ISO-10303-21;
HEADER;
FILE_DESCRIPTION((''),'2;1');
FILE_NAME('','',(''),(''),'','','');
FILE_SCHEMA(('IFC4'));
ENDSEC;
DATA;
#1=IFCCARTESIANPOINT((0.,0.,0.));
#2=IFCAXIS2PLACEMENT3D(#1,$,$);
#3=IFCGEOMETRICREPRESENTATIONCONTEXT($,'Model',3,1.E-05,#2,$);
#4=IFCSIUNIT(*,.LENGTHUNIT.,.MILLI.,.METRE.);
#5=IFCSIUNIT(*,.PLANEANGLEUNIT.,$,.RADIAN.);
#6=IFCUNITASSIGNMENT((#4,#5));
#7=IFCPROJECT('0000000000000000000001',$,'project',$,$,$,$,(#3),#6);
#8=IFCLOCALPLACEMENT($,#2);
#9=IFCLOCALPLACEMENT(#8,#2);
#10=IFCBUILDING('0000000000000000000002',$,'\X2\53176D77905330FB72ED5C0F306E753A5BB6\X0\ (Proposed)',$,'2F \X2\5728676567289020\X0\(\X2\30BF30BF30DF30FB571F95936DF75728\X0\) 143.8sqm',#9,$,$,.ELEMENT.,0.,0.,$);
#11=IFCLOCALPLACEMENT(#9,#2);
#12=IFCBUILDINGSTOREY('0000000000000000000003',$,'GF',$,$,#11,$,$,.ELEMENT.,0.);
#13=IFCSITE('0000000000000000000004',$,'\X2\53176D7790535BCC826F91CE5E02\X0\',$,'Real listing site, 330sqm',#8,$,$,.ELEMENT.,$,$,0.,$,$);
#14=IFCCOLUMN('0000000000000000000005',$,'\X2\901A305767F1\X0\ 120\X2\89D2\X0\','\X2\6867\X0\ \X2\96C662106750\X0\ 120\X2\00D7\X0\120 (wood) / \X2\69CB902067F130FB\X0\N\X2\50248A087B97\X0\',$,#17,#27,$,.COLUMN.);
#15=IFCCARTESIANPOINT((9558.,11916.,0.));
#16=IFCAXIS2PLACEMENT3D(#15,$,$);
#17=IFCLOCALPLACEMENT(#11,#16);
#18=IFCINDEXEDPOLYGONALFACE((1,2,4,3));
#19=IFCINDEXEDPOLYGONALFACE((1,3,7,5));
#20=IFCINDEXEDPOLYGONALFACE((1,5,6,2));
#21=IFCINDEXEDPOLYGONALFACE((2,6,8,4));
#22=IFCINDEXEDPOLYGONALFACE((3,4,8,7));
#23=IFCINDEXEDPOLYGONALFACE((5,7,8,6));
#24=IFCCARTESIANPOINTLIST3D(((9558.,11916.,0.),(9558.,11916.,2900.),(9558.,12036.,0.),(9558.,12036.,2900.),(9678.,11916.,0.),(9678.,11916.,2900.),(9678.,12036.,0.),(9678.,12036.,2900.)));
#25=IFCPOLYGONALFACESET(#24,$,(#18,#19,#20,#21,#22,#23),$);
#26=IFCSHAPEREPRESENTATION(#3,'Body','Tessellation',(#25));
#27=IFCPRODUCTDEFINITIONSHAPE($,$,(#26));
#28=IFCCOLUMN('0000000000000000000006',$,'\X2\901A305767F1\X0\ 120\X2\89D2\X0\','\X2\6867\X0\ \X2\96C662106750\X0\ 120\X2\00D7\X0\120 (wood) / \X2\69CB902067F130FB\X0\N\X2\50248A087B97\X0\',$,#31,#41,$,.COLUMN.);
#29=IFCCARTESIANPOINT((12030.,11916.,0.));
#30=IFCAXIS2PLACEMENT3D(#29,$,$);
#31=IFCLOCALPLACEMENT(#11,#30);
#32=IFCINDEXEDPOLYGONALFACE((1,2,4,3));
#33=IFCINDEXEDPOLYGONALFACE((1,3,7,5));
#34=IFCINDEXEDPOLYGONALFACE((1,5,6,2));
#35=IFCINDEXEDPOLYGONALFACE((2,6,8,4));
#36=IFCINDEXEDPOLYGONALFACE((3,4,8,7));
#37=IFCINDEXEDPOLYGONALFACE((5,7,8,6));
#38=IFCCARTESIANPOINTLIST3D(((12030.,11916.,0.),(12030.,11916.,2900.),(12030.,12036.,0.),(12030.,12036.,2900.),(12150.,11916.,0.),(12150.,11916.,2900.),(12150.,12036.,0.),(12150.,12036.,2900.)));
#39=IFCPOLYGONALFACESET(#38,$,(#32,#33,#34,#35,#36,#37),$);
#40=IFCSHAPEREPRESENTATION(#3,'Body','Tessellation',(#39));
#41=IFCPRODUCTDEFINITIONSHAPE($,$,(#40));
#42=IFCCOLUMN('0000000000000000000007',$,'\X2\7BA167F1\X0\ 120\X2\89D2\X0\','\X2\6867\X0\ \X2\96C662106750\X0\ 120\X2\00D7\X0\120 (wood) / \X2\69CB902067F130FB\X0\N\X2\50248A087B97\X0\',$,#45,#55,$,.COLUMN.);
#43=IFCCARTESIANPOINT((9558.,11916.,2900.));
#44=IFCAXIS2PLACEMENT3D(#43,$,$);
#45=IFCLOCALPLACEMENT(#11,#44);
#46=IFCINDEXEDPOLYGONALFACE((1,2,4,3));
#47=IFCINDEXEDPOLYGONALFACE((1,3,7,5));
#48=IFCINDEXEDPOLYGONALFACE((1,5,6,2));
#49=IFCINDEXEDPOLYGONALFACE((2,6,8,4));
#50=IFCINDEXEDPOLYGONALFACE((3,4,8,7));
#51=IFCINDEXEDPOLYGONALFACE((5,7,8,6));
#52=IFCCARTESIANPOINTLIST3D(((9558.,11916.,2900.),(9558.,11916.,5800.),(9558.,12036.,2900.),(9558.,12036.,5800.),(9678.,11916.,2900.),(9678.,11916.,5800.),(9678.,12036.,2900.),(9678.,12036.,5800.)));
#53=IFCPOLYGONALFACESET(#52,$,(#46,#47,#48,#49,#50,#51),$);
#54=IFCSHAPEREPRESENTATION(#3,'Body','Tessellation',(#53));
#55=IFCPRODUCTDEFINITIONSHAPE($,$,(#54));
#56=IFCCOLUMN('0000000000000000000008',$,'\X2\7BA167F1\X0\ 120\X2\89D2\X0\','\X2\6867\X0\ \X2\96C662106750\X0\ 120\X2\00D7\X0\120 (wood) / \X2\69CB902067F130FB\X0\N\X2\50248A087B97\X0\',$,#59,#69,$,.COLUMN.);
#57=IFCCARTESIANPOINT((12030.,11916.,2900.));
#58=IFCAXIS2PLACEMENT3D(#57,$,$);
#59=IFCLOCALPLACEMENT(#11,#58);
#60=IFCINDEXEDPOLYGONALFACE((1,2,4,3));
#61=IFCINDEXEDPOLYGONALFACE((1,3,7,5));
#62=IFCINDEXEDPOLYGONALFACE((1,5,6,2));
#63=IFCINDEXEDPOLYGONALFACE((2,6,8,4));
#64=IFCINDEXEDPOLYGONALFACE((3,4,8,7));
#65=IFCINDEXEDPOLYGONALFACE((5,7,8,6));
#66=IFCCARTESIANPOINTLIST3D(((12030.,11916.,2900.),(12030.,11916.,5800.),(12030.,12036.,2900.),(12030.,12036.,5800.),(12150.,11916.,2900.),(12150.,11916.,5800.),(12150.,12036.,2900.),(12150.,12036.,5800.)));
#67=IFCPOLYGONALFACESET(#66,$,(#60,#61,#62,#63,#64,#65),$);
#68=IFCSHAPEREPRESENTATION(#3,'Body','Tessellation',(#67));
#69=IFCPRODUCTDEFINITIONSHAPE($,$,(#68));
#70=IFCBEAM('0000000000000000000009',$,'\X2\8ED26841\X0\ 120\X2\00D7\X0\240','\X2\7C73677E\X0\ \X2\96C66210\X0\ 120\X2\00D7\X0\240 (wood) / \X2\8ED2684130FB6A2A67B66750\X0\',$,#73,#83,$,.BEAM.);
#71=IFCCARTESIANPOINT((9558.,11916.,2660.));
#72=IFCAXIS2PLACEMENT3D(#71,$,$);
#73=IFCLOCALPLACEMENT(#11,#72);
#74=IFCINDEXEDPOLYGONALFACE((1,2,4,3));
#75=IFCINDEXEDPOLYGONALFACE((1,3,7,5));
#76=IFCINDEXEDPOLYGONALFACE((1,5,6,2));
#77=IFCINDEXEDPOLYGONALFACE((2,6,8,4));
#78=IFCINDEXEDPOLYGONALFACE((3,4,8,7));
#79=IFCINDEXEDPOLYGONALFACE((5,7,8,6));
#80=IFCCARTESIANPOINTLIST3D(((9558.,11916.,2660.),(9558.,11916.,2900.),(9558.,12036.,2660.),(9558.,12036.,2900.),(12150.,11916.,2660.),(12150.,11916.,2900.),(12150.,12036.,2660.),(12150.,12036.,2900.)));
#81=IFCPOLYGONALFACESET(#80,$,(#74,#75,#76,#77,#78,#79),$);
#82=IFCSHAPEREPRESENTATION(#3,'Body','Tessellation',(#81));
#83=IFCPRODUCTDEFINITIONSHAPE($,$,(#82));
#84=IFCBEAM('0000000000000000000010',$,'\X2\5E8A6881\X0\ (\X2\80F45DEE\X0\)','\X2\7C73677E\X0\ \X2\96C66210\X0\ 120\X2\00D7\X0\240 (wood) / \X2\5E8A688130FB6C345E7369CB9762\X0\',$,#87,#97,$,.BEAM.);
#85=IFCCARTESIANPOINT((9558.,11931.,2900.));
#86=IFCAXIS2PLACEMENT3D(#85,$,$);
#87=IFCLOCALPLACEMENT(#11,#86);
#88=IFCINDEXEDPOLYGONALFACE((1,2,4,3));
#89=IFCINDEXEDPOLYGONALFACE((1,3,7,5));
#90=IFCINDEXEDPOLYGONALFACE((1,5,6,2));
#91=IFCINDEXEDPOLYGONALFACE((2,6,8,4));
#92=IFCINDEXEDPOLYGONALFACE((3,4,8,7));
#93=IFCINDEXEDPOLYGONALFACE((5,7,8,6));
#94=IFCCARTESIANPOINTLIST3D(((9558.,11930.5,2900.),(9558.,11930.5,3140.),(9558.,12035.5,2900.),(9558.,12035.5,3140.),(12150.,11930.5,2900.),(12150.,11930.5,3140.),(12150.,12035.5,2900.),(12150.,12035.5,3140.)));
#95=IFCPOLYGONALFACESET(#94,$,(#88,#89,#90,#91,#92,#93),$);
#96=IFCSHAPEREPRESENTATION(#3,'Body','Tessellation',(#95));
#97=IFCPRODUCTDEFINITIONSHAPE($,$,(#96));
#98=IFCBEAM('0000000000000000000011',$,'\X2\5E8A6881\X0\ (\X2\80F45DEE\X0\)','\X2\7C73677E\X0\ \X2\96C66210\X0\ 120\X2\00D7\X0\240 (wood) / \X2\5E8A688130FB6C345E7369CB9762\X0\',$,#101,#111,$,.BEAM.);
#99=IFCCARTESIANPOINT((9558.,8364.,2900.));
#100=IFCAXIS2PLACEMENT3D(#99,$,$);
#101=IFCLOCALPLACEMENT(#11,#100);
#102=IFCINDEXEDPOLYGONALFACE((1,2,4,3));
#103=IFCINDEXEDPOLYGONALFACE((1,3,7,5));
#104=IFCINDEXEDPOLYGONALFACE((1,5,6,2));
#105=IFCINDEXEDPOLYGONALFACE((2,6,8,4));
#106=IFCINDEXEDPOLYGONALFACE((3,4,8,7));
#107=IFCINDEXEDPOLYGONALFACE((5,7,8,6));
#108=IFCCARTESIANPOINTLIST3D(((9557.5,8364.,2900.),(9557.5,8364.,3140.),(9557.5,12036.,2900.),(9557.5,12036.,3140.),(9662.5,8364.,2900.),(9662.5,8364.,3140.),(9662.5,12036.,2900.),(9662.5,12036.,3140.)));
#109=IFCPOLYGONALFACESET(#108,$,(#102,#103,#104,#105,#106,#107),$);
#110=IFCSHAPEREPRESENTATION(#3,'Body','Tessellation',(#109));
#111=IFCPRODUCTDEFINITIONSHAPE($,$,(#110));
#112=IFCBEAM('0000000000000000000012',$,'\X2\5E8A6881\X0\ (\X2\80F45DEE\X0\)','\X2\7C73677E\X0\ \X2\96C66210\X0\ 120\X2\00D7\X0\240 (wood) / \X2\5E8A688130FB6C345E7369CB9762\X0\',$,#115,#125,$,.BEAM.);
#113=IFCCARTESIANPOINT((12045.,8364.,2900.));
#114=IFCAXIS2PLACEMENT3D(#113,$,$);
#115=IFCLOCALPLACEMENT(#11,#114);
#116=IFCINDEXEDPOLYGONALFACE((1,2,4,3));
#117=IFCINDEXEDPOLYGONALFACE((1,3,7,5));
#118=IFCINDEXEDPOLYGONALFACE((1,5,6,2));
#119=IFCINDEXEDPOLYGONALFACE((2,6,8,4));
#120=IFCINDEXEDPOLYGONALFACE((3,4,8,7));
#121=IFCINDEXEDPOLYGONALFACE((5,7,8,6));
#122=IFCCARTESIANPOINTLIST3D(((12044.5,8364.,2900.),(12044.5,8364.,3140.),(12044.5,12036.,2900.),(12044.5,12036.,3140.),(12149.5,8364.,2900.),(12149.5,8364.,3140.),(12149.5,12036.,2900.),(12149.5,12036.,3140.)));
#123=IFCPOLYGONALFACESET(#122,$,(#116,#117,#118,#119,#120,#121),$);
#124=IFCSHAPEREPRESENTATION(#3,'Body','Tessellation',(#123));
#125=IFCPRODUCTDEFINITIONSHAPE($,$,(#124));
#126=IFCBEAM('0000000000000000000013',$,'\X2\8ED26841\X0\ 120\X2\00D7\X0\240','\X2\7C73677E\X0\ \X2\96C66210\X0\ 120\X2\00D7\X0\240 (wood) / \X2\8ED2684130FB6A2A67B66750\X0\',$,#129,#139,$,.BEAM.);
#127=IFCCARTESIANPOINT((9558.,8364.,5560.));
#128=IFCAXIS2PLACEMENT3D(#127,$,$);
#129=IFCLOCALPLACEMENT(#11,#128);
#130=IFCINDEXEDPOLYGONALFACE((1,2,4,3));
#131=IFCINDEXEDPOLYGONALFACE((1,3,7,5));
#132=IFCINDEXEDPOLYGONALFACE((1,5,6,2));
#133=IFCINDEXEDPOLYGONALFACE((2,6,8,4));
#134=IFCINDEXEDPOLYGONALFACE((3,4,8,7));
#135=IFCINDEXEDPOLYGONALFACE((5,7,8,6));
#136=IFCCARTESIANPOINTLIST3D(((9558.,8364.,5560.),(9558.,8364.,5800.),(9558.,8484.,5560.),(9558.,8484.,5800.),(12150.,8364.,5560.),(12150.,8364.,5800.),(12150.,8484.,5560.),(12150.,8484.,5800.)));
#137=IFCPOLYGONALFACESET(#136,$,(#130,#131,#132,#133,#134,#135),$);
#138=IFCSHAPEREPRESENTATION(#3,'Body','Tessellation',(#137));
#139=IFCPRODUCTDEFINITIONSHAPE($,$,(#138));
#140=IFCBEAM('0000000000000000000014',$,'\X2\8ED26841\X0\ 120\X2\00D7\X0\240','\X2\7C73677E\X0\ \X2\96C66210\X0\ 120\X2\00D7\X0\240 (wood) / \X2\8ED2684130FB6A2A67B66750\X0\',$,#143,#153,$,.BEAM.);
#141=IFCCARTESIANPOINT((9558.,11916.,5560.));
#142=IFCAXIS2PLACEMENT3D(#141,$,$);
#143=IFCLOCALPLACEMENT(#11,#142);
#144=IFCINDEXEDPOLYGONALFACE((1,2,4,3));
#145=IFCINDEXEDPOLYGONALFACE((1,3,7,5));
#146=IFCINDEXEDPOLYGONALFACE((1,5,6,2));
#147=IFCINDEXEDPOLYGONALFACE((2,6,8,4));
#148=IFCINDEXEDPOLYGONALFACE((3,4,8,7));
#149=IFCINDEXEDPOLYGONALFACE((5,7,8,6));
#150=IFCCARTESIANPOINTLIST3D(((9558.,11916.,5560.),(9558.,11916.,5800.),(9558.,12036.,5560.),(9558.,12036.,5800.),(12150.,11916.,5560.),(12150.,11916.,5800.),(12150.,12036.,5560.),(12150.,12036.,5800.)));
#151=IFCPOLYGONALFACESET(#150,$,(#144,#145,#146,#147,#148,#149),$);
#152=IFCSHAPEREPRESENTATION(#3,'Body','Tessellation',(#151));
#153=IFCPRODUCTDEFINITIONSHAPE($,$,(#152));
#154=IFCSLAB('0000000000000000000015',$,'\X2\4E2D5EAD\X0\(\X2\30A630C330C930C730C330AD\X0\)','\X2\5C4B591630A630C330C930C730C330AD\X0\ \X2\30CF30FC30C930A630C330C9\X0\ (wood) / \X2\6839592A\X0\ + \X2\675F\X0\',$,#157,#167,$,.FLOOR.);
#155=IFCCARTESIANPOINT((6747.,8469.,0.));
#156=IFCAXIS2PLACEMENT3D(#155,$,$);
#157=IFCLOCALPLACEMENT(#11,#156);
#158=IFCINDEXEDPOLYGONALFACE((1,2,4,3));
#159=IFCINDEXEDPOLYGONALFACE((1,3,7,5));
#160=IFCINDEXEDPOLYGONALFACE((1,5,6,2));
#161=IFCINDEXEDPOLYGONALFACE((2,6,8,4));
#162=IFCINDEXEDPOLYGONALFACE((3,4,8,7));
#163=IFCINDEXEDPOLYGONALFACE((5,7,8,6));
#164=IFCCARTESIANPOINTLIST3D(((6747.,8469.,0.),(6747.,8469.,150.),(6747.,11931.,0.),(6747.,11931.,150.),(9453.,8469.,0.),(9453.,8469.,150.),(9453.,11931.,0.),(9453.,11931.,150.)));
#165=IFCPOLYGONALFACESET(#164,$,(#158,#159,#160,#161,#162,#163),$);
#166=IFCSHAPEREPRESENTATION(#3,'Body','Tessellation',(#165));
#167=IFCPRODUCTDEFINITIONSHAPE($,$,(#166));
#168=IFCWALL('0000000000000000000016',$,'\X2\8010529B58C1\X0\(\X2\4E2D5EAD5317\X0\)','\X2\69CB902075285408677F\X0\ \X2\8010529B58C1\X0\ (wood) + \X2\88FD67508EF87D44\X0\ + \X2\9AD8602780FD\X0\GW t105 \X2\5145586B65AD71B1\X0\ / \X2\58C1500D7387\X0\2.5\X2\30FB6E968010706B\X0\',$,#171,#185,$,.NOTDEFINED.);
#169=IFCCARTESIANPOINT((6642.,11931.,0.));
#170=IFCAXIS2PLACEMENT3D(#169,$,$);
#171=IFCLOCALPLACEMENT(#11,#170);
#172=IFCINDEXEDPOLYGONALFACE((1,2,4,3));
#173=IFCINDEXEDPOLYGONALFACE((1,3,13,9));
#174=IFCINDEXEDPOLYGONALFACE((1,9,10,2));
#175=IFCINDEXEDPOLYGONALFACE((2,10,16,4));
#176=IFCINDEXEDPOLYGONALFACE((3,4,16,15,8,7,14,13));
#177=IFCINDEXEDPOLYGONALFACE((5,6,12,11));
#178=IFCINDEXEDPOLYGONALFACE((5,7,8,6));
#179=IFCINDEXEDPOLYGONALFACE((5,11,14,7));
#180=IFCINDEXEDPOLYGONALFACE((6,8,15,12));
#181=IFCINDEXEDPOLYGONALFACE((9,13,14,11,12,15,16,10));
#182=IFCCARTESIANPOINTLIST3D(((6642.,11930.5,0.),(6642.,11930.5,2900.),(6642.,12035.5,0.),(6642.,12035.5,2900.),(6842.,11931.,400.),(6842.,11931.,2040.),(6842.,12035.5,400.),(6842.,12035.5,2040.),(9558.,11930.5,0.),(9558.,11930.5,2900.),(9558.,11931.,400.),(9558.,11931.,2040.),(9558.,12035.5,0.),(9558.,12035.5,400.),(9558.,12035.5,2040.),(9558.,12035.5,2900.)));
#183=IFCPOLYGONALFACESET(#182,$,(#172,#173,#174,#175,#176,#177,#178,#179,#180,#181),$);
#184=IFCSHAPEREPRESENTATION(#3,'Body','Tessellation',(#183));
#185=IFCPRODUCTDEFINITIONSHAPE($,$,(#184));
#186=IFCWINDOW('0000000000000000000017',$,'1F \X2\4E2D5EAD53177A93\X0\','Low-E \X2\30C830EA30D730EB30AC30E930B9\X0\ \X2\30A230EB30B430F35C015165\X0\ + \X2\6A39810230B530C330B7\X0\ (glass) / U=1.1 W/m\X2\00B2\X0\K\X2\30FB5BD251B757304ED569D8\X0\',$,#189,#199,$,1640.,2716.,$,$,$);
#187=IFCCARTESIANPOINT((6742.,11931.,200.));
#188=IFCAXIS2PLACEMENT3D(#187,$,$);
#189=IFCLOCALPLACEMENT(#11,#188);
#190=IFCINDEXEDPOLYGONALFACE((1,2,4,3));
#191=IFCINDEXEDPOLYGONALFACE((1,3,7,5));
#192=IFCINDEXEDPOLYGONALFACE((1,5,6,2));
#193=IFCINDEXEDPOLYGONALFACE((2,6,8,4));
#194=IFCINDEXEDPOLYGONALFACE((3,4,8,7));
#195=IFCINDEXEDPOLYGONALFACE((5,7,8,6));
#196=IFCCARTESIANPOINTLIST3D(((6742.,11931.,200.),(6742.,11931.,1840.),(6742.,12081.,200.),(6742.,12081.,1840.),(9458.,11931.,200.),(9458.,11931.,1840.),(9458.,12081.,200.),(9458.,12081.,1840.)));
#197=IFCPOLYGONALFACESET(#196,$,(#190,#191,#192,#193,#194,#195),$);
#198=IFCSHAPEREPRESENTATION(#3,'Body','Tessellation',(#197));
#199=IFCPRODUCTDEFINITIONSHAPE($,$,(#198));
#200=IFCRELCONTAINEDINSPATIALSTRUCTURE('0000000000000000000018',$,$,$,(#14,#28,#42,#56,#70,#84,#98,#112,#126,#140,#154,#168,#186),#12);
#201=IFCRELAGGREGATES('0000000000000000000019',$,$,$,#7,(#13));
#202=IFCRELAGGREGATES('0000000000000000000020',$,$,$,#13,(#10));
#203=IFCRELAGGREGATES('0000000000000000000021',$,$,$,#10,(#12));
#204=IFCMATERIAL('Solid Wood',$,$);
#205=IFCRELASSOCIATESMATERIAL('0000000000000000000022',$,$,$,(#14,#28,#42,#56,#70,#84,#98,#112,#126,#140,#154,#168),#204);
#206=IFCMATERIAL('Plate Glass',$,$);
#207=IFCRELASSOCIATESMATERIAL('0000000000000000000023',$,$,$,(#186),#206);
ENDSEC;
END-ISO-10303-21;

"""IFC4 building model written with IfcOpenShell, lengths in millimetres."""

from ifc_helpers import new_model, si_unit, frame, frame_2d, origin, place, context, project, spatial, rectangle, extrude, material, element, fill, save


model = new_model("IFC4")

# Units and contexts
model_context = context("Model", 3, precision=1e-05, world=origin())
ifc_project = project(units=[si_unit("LENGTHUNIT", "METRE", prefix="MILLI"), si_unit("PLANEANGLEUNIT", "RADIAN")], contexts=[model_context])

# Site, building, storey
site_placement = place(None, origin())
site = spatial("IfcSite", under=ifc_project, at=site_placement, Name="北海道富良野市", ObjectType="Real listing site, 330sqm", CompositionType="ELEMENT", RefElevation=0.0)
building_placement = place(site_placement, origin())
building = spatial("IfcBuilding", under=site, at=building_placement, Name="北海道・狭小の町家 (Proposed)", ObjectType="2F 在来木造(タタミ・土間混在) 143.8sqm", CompositionType="ELEMENT", ElevationOfRefHeight=0.0, ElevationOfTerrain=0.0)
storey_placement = place(building_placement, origin())
storey = spatial("IfcBuildingStorey", under=building, at=storey_placement, Name="GF", CompositionType="ELEMENT", Elevation=0.0)

# Columns
ifc_material_1 = material(Name="Solid Wood")
column_1_placement = place(storey_placement, frame((9558.0, 11916.0, 0.0)))
element("IfcColumn", 1, at=column_1_placement, inside=storey, material=ifc_material_1, Name="通し柱 120角", Description="桧 集成材 120×120 (wood) / 構造柱・N値計算", PredefinedType="COLUMN", context=model_context, shape_type="SweptSolid", body=[
    extrude(rectangle(XDim=120.0, YDim=120.0, at=frame_2d((60.0, 60.0))), frame((9558.0, 11916.0, 0.0)), (0.0, 0.0, 1.0), 2900.0),
])
column_2_placement = place(storey_placement, frame((12030.0, 11916.0, 0.0)))
element("IfcColumn", 2, at=column_2_placement, inside=storey, material=ifc_material_1, Name="通し柱 120角", Description="桧 集成材 120×120 (wood) / 構造柱・N値計算", PredefinedType="COLUMN", context=model_context, shape_type="SweptSolid", body=[
    extrude(rectangle(XDim=120.0, YDim=120.0, at=frame_2d((60.0, 60.0))), frame((12030.0, 11916.0, 0.0)), (0.0, 0.0, 1.0), 2900.0),
])
column_3_placement = place(storey_placement, frame((9558.0, 11916.0, 2900.0)))
element("IfcColumn", 3, at=column_3_placement, inside=storey, material=ifc_material_1, Name="管柱 120角", Description="桧 集成材 120×120 (wood) / 構造柱・N値計算", PredefinedType="COLUMN", context=model_context, shape_type="SweptSolid", body=[
    extrude(rectangle(XDim=120.0, YDim=120.0, at=frame_2d((60.0, 60.0))), frame((9558.0, 11916.0, 2900.0)), (0.0, 0.0, 1.0), 2900.0),
])
column_4_placement = place(storey_placement, frame((12030.0, 11916.0, 2900.0)))
element("IfcColumn", 4, at=column_4_placement, inside=storey, material=ifc_material_1, Name="管柱 120角", Description="桧 集成材 120×120 (wood) / 構造柱・N値計算", PredefinedType="COLUMN", context=model_context, shape_type="SweptSolid", body=[
    extrude(rectangle(XDim=120.0, YDim=120.0, at=frame_2d((60.0, 60.0))), frame((12030.0, 11916.0, 2900.0)), (0.0, 0.0, 1.0), 2900.0),
])

# Beams
beam_1_placement = place(storey_placement, frame((9558.0, 11916.0, 2660.0)))
element("IfcBeam", 5, at=beam_1_placement, inside=storey, material=ifc_material_1, Name="軒桁 120×240", Description="米松 集成 120×240 (wood) / 軒桁・横架材", PredefinedType="BEAM", context=model_context, shape_type="SweptSolid", body=[
    extrude(rectangle(XDim=2592.0, YDim=120.0, at=frame_2d((1296.0, 60.0))), frame((9558.0, 11916.0, 2660.0)), (0.0, 0.0, 1.0), 240.0),
])
beam_2_placement = place(storey_placement, frame((9558.0, 11931.0, 2900.0)))
element("IfcBeam", 6, at=beam_2_placement, inside=storey, material=ifc_material_1, Name="床梁 (胴差)", Description="米松 集成 120×240 (wood) / 床梁・水平構面", PredefinedType="BEAM", context=model_context, shape_type="SweptSolid", body=[
    extrude(rectangle(XDim=2592.0, YDim=105.0, at=frame_2d((1296.0, 52.0))), frame((9558.0, 11931.0, 2900.0)), (0.0, 0.0, 1.0), 240.0),
])
beam_3_placement = place(storey_placement, frame((9558.0, 8364.0, 2900.0)))
element("IfcBeam", 7, at=beam_3_placement, inside=storey, material=ifc_material_1, Name="床梁 (胴差)", Description="米松 集成 120×240 (wood) / 床梁・水平構面", PredefinedType="BEAM", context=model_context, shape_type="SweptSolid", body=[
    extrude(rectangle(XDim=105.0, YDim=3672.0, at=frame_2d((52.0, 1836.0))), frame((9558.0, 8364.0, 2900.0)), (0.0, 0.0, 1.0), 240.0),
])
beam_4_placement = place(storey_placement, frame((12045.0, 8364.0, 2900.0)))
element("IfcBeam", 8, at=beam_4_placement, inside=storey, material=ifc_material_1, Name="床梁 (胴差)", Description="米松 集成 120×240 (wood) / 床梁・水平構面", PredefinedType="BEAM", context=model_context, shape_type="SweptSolid", body=[
    extrude(rectangle(XDim=105.0, YDim=3672.0, at=frame_2d((52.0, 1836.0))), frame((12045.0, 8364.0, 2900.0)), (0.0, 0.0, 1.0), 240.0),
])
beam_5_placement = place(storey_placement, frame((9558.0, 8364.0, 5560.0)))
element("IfcBeam", 9, at=beam_5_placement, inside=storey, material=ifc_material_1, Name="軒桁 120×240", Description="米松 集成 120×240 (wood) / 軒桁・横架材", PredefinedType="BEAM", context=model_context, shape_type="SweptSolid", body=[
    extrude(rectangle(XDim=2592.0, YDim=120.0, at=frame_2d((1296.0, 60.0))), frame((9558.0, 8364.0, 5560.0)), (0.0, 0.0, 1.0), 240.0),
])
beam_6_placement = place(storey_placement, frame((9558.0, 11916.0, 5560.0)))
element("IfcBeam", 10, at=beam_6_placement, inside=storey, material=ifc_material_1, Name="軒桁 120×240", Description="米松 集成 120×240 (wood) / 軒桁・横架材", PredefinedType="BEAM", context=model_context, shape_type="SweptSolid", body=[
    extrude(rectangle(XDim=2592.0, YDim=120.0, at=frame_2d((1296.0, 60.0))), frame((9558.0, 11916.0, 5560.0)), (0.0, 0.0, 1.0), 240.0),
])

# Slab
slab_placement = place(storey_placement, frame((6747.0, 8469.0, 0.0)))
element("IfcSlab", 11, at=slab_placement, inside=storey, material=ifc_material_1, Name="中庭(ウッドデッキ)", Description="屋外ウッドデッキ ハードウッド (wood) / 根太 + 束", PredefinedType="FLOOR", context=model_context, shape_type="SweptSolid", body=[
    extrude(rectangle(XDim=2706.0, YDim=3462.0, at=frame_2d((1353.0, 1731.0))), frame((6747.0, 8469.0, 0.0)), (0.0, 0.0, 1.0), 150.0),
])

# Wall, opening, window
wall_1_placement = place(storey_placement, frame((6642.0, 11931.0, 0.0)))
wall_1 = element("IfcWall", 12, at=wall_1_placement, inside=storey, material=ifc_material_1, Name="耐力壁(中庭北)", Description="構造用合板 耐力壁 (wood) + 製材軸組 + 高性能GW t105 充填断熱 / 壁倍率2.5・準耐火", PredefinedType="NOTDEFINED", context=model_context, shape_type="SweptSolid", body=[
    extrude(rectangle(XDim=2916.0, YDim=105.0, at=frame_2d((1458.0, 52.0))), frame((6642.0, 11931.0, 0.0)), (0.0, 0.0, 1.0), 2900.0),
])
opening_1_placement = place(storey_placement, frame((6742.0, 11931.0, 200.0)))
opening_1 = element("IfcOpeningElement", 13, at=opening_1_placement, cuts=wall_1, PredefinedType="NOTDEFINED", context=model_context, shape_type="SweptSolid", body=[
    extrude(rectangle(XDim=2716.0, YDim=150.0, at=frame_2d((1358.0, 75.0))), frame((6742.0, 11931.0, 200.0)), (0.0, 0.0, 1.0), 1640.0),
])
ifc_material_2 = material(Name="Plate Glass")
window_1_placement = place(storey_placement, frame((6742.0, 11931.0, 200.0)))
window_1 = element("IfcWindow", 14, at=window_1_placement, inside=storey, material=ifc_material_2, Name="1F 中庭北窓", Description="Low-E トリプルガラス アルゴン封入 + 樹脂サッシ (glass) / U=1.1 W/m²K・寒冷地仕様", OverallHeight=1640.0, OverallWidth=2716.0, context=model_context, shape_type="SweptSolid", body=[
    extrude(rectangle(XDim=2716.0, YDim=150.0, at=frame_2d((1358.0, 75.0))), frame((6742.0, 11931.0, 200.0)), (0.0, 0.0, 1.0), 1640.0),
])
fill(opening_1, window_1)

save(model, "model.ifc")
